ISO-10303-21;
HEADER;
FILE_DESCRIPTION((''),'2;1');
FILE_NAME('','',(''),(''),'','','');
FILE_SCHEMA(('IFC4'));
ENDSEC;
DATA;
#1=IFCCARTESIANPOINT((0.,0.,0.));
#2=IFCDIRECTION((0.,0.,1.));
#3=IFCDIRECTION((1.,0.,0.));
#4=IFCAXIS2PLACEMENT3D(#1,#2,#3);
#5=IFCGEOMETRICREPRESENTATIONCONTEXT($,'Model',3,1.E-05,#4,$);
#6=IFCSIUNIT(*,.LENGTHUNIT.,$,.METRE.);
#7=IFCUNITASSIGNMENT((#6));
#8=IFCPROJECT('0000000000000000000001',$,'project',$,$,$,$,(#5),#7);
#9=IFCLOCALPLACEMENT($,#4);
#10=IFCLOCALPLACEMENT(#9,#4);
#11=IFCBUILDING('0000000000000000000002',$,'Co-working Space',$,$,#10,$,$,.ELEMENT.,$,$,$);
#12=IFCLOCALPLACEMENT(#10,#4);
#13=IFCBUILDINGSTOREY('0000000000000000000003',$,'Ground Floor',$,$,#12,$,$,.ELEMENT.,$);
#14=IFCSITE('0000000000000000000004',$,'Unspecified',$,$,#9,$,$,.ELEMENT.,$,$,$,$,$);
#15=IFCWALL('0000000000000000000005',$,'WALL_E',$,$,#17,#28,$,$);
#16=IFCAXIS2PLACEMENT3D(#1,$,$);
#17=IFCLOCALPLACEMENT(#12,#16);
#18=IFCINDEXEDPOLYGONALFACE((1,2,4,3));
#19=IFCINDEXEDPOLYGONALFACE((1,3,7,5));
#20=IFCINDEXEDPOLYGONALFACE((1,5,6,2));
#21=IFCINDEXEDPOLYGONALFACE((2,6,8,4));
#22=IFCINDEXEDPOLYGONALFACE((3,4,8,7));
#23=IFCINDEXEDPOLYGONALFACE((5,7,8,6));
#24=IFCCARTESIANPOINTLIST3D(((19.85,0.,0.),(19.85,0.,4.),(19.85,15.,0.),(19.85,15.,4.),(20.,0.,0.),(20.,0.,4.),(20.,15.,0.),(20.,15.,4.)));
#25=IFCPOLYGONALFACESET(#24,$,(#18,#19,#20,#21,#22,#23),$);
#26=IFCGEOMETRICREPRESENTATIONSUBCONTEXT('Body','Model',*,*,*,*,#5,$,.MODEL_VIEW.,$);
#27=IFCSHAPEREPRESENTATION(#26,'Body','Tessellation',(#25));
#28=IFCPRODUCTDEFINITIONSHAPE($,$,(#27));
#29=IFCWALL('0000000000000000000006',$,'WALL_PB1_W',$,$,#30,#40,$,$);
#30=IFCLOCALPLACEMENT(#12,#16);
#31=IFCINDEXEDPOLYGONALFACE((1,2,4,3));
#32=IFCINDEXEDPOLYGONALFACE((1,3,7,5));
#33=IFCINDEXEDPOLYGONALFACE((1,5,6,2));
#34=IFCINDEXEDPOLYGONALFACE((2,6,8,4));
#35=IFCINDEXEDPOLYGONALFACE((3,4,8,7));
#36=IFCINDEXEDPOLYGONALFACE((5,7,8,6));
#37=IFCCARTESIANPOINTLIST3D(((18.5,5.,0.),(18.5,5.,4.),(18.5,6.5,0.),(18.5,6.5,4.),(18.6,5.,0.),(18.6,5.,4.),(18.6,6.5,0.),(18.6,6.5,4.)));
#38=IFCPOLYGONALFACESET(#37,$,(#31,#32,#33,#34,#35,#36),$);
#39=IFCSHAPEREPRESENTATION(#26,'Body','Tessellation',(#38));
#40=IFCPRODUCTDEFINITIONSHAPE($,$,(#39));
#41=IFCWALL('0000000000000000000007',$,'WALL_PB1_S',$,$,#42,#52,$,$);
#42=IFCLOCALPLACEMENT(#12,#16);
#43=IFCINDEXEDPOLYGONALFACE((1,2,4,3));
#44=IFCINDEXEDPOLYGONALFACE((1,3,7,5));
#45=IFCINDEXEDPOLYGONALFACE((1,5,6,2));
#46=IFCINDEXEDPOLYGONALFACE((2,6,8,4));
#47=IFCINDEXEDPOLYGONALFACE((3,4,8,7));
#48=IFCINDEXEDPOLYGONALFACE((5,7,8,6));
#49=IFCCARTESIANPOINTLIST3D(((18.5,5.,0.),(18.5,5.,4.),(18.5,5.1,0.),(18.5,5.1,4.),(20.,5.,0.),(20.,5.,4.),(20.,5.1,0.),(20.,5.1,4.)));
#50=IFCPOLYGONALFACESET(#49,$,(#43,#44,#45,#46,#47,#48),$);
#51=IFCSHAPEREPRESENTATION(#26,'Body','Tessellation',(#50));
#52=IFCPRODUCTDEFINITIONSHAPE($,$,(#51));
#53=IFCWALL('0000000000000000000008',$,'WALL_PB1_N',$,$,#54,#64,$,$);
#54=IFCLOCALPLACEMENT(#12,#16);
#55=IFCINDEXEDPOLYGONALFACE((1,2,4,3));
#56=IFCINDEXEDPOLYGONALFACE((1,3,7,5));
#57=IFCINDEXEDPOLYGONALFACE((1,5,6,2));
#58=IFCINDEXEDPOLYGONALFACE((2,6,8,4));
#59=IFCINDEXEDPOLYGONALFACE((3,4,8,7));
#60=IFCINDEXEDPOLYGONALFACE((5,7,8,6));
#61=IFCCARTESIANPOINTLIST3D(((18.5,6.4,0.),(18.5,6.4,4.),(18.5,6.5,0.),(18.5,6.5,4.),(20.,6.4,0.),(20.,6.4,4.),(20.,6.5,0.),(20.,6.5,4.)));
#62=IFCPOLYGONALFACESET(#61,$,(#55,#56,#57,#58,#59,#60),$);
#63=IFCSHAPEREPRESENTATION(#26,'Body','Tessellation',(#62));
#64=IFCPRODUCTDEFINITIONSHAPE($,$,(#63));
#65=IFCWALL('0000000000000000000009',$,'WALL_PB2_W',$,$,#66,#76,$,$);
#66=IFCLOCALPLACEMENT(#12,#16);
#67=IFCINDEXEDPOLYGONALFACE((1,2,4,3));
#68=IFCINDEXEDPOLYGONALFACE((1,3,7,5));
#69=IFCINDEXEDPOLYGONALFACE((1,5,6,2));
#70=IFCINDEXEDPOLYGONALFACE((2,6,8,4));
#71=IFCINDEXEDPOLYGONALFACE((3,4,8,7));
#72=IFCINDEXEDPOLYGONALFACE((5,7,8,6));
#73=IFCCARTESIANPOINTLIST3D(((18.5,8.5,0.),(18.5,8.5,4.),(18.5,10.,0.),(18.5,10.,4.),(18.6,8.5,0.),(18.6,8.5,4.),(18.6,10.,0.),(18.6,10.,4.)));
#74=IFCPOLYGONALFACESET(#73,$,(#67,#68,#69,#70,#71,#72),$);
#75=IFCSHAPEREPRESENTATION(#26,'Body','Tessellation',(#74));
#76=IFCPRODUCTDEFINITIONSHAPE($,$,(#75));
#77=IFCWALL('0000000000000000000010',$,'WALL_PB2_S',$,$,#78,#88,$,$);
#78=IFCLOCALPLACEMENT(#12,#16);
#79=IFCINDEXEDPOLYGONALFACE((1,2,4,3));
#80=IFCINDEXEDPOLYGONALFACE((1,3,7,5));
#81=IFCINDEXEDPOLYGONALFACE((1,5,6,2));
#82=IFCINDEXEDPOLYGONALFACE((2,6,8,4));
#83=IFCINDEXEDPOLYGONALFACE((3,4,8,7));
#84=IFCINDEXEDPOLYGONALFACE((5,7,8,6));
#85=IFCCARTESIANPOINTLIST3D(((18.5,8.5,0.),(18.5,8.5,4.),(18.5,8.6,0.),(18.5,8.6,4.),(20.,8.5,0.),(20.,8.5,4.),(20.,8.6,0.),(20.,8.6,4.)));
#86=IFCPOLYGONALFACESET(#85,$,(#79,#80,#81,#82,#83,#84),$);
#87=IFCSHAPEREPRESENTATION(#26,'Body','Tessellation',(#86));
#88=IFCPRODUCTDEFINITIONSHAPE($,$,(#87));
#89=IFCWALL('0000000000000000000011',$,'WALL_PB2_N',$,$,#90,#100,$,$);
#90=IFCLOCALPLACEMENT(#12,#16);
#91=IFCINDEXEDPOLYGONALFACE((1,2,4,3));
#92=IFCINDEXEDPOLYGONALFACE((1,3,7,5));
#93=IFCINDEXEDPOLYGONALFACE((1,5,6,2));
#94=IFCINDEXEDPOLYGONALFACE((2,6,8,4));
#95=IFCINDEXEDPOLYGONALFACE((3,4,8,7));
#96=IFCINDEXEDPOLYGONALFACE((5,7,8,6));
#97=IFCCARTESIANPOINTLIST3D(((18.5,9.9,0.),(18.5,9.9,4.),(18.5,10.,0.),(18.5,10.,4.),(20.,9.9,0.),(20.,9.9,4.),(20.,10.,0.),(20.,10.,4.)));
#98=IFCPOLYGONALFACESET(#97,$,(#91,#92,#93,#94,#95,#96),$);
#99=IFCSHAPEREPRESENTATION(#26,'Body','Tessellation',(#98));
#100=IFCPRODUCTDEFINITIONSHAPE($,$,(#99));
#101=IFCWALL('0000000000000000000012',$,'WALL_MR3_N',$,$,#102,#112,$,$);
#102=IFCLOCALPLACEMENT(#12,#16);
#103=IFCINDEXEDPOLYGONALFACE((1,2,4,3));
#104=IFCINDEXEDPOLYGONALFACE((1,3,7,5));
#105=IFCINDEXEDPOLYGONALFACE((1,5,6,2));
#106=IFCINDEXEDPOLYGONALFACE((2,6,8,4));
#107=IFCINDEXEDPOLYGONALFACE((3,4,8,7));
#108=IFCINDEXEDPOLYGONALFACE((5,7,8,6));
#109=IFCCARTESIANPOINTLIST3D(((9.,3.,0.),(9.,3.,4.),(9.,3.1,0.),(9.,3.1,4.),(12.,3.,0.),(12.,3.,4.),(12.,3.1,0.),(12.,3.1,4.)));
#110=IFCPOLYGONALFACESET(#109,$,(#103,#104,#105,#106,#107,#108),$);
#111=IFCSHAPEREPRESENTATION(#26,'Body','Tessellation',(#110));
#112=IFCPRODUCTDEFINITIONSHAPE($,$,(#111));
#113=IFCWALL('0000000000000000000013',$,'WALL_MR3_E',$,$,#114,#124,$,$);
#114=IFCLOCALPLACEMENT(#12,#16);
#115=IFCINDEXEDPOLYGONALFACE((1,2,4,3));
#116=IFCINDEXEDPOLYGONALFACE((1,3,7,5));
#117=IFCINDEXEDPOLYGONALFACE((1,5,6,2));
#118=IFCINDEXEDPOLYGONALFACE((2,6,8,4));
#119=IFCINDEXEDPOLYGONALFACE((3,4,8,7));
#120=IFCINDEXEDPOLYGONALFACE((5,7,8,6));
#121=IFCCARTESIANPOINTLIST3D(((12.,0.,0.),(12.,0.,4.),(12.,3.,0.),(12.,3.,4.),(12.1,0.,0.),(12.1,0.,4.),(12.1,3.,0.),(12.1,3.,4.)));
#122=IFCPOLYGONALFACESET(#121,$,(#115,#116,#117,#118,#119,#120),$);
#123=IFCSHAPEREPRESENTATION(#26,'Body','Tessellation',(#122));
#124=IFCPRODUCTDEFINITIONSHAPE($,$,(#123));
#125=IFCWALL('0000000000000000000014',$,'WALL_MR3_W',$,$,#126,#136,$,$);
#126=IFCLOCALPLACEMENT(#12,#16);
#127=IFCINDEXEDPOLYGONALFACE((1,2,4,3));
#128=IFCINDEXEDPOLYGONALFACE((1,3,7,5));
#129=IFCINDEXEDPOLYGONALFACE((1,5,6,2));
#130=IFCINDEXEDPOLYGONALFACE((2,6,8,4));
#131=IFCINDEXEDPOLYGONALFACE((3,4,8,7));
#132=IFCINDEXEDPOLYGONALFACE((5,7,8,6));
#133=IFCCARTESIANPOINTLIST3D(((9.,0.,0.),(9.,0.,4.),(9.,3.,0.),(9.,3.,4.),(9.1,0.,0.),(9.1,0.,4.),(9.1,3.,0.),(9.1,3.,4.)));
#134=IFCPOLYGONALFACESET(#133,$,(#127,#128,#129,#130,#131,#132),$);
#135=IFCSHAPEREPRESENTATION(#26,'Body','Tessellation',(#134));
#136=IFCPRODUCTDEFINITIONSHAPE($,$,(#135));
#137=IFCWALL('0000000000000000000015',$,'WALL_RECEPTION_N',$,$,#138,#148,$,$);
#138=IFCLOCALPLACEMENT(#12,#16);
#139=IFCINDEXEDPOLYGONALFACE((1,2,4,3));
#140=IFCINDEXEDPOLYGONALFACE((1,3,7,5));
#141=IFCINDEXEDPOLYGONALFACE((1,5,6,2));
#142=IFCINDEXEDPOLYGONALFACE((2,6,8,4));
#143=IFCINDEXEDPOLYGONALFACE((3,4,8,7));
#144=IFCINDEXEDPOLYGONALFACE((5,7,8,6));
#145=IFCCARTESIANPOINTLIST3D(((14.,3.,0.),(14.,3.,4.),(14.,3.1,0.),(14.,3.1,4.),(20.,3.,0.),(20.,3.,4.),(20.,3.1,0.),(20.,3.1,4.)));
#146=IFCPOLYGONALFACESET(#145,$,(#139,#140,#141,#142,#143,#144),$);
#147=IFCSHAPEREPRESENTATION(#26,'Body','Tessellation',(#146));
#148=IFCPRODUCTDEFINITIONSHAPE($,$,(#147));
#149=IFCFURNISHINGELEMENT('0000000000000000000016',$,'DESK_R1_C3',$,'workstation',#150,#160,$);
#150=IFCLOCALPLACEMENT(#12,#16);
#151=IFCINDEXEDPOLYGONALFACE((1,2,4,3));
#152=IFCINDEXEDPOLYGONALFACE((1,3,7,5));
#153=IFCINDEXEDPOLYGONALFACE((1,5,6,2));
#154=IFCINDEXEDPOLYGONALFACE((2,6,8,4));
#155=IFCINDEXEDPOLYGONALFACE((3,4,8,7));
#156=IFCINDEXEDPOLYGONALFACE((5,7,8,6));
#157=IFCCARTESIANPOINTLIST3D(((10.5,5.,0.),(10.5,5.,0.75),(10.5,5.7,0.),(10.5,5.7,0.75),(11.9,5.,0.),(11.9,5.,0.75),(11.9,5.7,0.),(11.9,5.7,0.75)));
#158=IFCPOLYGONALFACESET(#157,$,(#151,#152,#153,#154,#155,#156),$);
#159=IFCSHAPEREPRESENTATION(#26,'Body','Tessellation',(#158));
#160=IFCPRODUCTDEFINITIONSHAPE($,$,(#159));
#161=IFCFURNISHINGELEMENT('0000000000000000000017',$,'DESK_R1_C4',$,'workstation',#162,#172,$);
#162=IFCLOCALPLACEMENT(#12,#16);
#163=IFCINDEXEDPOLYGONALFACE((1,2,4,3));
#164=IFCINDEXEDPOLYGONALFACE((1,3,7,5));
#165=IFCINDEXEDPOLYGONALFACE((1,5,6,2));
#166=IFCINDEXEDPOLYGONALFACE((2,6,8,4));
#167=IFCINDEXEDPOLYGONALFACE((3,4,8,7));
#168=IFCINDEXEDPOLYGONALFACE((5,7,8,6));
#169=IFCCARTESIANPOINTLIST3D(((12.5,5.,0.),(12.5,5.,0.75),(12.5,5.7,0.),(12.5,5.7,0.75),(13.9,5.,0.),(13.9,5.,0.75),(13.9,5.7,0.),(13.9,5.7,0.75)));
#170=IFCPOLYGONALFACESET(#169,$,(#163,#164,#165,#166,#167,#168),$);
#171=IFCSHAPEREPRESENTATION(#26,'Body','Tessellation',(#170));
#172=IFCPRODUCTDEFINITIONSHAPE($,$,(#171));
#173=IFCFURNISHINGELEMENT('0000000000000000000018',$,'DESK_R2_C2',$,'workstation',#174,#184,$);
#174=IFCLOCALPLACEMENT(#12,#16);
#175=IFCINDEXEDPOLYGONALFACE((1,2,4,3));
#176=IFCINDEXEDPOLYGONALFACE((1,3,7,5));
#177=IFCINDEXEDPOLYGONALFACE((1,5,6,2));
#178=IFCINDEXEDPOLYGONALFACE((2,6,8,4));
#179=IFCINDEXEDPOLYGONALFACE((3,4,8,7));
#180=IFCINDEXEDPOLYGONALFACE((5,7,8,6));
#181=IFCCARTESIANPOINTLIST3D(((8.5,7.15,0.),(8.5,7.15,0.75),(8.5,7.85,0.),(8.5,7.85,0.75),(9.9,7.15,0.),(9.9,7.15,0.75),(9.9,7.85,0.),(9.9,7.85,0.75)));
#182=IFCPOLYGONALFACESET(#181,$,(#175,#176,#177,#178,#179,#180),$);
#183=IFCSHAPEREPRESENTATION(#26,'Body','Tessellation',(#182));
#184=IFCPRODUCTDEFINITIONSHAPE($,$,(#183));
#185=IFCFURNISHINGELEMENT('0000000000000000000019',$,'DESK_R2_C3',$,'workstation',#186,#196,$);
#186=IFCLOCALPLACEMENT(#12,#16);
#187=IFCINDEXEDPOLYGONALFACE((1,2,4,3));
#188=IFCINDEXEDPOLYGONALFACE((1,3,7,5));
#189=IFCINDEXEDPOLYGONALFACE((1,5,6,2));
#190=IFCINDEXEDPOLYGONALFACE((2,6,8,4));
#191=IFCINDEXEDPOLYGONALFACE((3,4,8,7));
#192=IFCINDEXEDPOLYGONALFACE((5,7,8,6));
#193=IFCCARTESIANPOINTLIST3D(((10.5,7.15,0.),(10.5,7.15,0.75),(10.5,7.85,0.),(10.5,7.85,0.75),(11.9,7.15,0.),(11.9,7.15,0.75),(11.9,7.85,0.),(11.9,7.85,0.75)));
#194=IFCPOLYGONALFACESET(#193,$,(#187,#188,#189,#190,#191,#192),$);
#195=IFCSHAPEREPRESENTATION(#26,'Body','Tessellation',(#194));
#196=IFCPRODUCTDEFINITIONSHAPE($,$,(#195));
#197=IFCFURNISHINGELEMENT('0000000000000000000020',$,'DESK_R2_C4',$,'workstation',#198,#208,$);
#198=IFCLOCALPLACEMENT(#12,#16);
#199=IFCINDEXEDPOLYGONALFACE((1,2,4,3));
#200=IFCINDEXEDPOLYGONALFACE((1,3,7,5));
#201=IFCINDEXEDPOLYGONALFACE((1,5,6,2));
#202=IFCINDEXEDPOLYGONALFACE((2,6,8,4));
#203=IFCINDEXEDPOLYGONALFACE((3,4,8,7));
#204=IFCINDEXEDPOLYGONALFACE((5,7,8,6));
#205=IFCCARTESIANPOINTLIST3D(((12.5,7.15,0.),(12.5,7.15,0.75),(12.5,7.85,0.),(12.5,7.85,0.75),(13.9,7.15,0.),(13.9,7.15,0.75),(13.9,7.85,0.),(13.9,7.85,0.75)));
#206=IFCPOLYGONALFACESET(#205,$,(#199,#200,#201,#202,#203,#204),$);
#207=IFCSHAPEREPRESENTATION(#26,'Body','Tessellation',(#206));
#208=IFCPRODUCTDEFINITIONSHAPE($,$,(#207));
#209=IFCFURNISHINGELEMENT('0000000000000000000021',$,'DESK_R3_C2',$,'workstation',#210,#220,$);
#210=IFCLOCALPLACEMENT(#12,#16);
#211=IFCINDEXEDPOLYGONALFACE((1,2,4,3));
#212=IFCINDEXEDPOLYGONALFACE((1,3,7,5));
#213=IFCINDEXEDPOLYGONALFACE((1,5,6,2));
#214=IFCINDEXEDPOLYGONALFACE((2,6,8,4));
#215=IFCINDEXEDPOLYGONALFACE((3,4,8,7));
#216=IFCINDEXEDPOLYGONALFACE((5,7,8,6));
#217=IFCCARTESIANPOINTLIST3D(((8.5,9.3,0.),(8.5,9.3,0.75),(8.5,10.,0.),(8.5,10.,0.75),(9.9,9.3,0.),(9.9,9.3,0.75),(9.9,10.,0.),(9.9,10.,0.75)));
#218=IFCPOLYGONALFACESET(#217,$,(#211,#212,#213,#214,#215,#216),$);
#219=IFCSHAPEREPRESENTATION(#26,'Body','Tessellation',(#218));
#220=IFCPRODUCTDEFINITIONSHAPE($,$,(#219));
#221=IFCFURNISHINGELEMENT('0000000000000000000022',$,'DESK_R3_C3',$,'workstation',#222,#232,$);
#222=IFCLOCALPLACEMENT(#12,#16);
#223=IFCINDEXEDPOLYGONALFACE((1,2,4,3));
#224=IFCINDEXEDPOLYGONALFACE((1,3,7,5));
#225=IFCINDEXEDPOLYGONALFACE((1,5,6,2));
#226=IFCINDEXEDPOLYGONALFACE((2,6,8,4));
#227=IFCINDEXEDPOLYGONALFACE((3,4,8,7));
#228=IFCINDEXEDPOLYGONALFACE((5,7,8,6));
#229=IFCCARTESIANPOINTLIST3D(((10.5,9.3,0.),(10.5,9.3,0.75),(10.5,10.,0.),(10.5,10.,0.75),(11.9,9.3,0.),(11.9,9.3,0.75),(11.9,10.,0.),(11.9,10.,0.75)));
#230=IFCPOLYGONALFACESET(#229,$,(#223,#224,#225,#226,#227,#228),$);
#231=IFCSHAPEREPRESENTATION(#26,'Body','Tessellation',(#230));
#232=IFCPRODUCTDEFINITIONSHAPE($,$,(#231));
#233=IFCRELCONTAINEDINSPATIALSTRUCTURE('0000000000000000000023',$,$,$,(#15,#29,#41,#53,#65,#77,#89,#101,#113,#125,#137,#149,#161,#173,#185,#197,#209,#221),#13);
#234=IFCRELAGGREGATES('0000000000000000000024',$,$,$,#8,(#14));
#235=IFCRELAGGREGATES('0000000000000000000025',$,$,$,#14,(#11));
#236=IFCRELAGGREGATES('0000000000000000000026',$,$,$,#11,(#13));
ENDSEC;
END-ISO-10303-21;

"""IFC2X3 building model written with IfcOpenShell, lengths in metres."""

from ifc_helpers import new_model, si_unit, frame, frame_2d, origin, origin_with_axes, place, context, subcontext, project, spatial, rectangle, extrude, element, save


model = new_model("IFC2X3")

# Units and contexts
model_context = context("Model", 3, precision=1e-05, world=origin_with_axes())
body_context = subcontext(model_context, "Body", "Model", "MODEL_VIEW")
ifc_project = project(units=[si_unit("LENGTHUNIT", "METRE")], contexts=[model_context])

# Site, building, storey
site_placement = place(None, origin_with_axes())
site = spatial("IfcSite", under=ifc_project, at=site_placement, Name="Unspecified", CompositionType="ELEMENT")
building_placement = place(site_placement, origin_with_axes())
building = spatial("IfcBuilding", under=site, at=building_placement, Name="Co-working Space", CompositionType="ELEMENT")
storey_placement = place(building_placement, origin_with_axes())
storey = spatial("IfcBuildingStorey", under=building, at=storey_placement, Name="Ground Floor", CompositionType="ELEMENT")

# Walls
wall_1_placement = place(storey_placement, frame((19.85, 0.0, 0.0), z_axis=(0.0, 0.0, 1.0), x_axis=(1.0, 0.0, 0.0)))
element("IfcWall", 1, at=wall_1_placement, inside=storey, Name="WALL_E", context=body_context, shape_type="SweptSolid", body=[
    extrude(rectangle(XDim=0.15, YDim=15.0, at=frame_2d((0.075, 7.5))), origin(), (0.0, 0.0, 1.0), 4.0),
])
wall_2_placement = place(storey_placement, frame((18.5, 5.0, 0.0), z_axis=(0.0, 0.0, 1.0), x_axis=(1.0, 0.0, 0.0)))
element("IfcWall", 2, at=wall_2_placement, inside=storey, Name="WALL_PB1_W", context=body_context, shape_type="SweptSolid", body=[
    extrude(rectangle(XDim=0.1, YDim=1.5, at=frame_2d((0.05, 0.75))), origin(), (0.0, 0.0, 1.0), 4.0),
])
for number, where, z_axis, x_axis, name in (
    (3, (18.5, 5.0, 0.0), (0.0, 0.0, 1.0), (1.0, 0.0, 0.0), "WALL_PB1_S"),
    (4, (18.5, 6.4, 0.0), (0.0, 0.0, 1.0), (1.0, 0.0, 0.0), "WALL_PB1_N"),
):
    element("IfcWall", number, at=place(storey_placement, frame(where, z_axis=z_axis, x_axis=x_axis)), inside=storey, Name=name, context=body_context, shape_type="SweptSolid", body=[
        extrude(rectangle(XDim=1.5, YDim=0.1, at=frame_2d((0.75, 0.05))), origin(), (0.0, 0.0, 1.0), 4.0),
    ])
wall_3_placement = place(storey_placement, frame((18.5, 8.5, 0.0), z_axis=(0.0, 0.0, 1.0), x_axis=(1.0, 0.0, 0.0)))
element("IfcWall", 5, at=wall_3_placement, inside=storey, Name="WALL_PB2_W", context=body_context, shape_type="SweptSolid", body=[
    extrude(rectangle(XDim=0.1, YDim=1.5, at=frame_2d((0.05, 0.75))), origin(), (0.0, 0.0, 1.0), 4.0),
])
for number, where, z_axis, x_axis, name in (
    (6, (18.5, 8.5, 0.0), (0.0, 0.0, 1.0), (1.0, 0.0, 0.0), "WALL_PB2_S"),
    (7, (18.5, 9.9, 0.0), (0.0, 0.0, 1.0), (1.0, 0.0, 0.0), "WALL_PB2_N"),
):
    element("IfcWall", number, at=place(storey_placement, frame(where, z_axis=z_axis, x_axis=x_axis)), inside=storey, Name=name, context=body_context, shape_type="SweptSolid", body=[
        extrude(rectangle(XDim=1.5, YDim=0.1, at=frame_2d((0.75, 0.05))), origin(), (0.0, 0.0, 1.0), 4.0),
    ])
wall_4_placement = place(storey_placement, frame((9.0, 3.0, 0.0), z_axis=(0.0, 0.0, 1.0), x_axis=(1.0, 0.0, 0.0)))
element("IfcWall", 8, at=wall_4_placement, inside=storey, Name="WALL_MR3_N", context=body_context, shape_type="SweptSolid", body=[
    extrude(rectangle(XDim=3.0, YDim=0.1, at=frame_2d((1.5, 0.05))), origin(), (0.0, 0.0, 1.0), 4.0),
])
for number, where, z_axis, x_axis, name in (
    (9, (12.0, 0.0, 0.0), (0.0, 0.0, 1.0), (1.0, 0.0, 0.0), "WALL_MR3_E"),
    (10, (9.0, 0.0, 0.0), (0.0, 0.0, 1.0), (1.0, 0.0, 0.0), "WALL_MR3_W"),
):
    element("IfcWall", number, at=place(storey_placement, frame(where, z_axis=z_axis, x_axis=x_axis)), inside=storey, Name=name, context=body_context, shape_type="SweptSolid", body=[
        extrude(rectangle(XDim=0.1, YDim=3.0, at=frame_2d((0.05, 1.5))), origin(), (0.0, 0.0, 1.0), 4.0),
    ])
wall_5_placement = place(storey_placement, frame((14.0, 3.0, 0.0), z_axis=(0.0, 0.0, 1.0), x_axis=(1.0, 0.0, 0.0)))
element("IfcWall", 11, at=wall_5_placement, inside=storey, Name="WALL_RECEPTION_N", context=body_context, shape_type="SweptSolid", body=[
    extrude(rectangle(XDim=6.0, YDim=0.1, at=frame_2d((3.0, 0.05))), origin(), (0.0, 0.0, 1.0), 4.0),
])

# Furnishing elements
for number, where, z_axis, x_axis, name in (
    (12, (10.5, 5.0, 0.0), (0.0, 0.0, 1.0), (1.0, 0.0, 0.0), "DESK_R1_C3"),
    (13, (12.5, 5.0, 0.0), (0.0, 0.0, 1.0), (1.0, 0.0, 0.0), "DESK_R1_C4"),
    (14, (8.5, 7.15, 0.0), (0.0, 0.0, 1.0), (1.0, 0.0, 0.0), "DESK_R2_C2"),
    (15, (10.5, 7.15, 0.0), (0.0, 0.0, 1.0), (1.0, 0.0, 0.0), "DESK_R2_C3"),
    (16, (12.5, 7.15, 0.0), (0.0, 0.0, 1.0), (1.0, 0.0, 0.0), "DESK_R2_C4"),
    (17, (8.5, 9.3, 0.0), (0.0, 0.0, 1.0), (1.0, 0.0, 0.0), "DESK_R3_C2"),
    (18, (10.5, 9.3, 0.0), (0.0, 0.0, 1.0), (1.0, 0.0, 0.0), "DESK_R3_C3"),
):
    element("IfcFurnishingElement", number, at=place(storey_placement, frame(where, z_axis=z_axis, x_axis=x_axis)), inside=storey, Name=name, ObjectType="workstation", context=body_context, shape_type="SweptSolid", body=[
        extrude(rectangle(XDim=1.4, YDim=0.7, at=frame_2d((0.7, 0.35))), origin(), (0.0, 0.0, 1.0), 0.75),
    ])

save(model, "model.ifc")
